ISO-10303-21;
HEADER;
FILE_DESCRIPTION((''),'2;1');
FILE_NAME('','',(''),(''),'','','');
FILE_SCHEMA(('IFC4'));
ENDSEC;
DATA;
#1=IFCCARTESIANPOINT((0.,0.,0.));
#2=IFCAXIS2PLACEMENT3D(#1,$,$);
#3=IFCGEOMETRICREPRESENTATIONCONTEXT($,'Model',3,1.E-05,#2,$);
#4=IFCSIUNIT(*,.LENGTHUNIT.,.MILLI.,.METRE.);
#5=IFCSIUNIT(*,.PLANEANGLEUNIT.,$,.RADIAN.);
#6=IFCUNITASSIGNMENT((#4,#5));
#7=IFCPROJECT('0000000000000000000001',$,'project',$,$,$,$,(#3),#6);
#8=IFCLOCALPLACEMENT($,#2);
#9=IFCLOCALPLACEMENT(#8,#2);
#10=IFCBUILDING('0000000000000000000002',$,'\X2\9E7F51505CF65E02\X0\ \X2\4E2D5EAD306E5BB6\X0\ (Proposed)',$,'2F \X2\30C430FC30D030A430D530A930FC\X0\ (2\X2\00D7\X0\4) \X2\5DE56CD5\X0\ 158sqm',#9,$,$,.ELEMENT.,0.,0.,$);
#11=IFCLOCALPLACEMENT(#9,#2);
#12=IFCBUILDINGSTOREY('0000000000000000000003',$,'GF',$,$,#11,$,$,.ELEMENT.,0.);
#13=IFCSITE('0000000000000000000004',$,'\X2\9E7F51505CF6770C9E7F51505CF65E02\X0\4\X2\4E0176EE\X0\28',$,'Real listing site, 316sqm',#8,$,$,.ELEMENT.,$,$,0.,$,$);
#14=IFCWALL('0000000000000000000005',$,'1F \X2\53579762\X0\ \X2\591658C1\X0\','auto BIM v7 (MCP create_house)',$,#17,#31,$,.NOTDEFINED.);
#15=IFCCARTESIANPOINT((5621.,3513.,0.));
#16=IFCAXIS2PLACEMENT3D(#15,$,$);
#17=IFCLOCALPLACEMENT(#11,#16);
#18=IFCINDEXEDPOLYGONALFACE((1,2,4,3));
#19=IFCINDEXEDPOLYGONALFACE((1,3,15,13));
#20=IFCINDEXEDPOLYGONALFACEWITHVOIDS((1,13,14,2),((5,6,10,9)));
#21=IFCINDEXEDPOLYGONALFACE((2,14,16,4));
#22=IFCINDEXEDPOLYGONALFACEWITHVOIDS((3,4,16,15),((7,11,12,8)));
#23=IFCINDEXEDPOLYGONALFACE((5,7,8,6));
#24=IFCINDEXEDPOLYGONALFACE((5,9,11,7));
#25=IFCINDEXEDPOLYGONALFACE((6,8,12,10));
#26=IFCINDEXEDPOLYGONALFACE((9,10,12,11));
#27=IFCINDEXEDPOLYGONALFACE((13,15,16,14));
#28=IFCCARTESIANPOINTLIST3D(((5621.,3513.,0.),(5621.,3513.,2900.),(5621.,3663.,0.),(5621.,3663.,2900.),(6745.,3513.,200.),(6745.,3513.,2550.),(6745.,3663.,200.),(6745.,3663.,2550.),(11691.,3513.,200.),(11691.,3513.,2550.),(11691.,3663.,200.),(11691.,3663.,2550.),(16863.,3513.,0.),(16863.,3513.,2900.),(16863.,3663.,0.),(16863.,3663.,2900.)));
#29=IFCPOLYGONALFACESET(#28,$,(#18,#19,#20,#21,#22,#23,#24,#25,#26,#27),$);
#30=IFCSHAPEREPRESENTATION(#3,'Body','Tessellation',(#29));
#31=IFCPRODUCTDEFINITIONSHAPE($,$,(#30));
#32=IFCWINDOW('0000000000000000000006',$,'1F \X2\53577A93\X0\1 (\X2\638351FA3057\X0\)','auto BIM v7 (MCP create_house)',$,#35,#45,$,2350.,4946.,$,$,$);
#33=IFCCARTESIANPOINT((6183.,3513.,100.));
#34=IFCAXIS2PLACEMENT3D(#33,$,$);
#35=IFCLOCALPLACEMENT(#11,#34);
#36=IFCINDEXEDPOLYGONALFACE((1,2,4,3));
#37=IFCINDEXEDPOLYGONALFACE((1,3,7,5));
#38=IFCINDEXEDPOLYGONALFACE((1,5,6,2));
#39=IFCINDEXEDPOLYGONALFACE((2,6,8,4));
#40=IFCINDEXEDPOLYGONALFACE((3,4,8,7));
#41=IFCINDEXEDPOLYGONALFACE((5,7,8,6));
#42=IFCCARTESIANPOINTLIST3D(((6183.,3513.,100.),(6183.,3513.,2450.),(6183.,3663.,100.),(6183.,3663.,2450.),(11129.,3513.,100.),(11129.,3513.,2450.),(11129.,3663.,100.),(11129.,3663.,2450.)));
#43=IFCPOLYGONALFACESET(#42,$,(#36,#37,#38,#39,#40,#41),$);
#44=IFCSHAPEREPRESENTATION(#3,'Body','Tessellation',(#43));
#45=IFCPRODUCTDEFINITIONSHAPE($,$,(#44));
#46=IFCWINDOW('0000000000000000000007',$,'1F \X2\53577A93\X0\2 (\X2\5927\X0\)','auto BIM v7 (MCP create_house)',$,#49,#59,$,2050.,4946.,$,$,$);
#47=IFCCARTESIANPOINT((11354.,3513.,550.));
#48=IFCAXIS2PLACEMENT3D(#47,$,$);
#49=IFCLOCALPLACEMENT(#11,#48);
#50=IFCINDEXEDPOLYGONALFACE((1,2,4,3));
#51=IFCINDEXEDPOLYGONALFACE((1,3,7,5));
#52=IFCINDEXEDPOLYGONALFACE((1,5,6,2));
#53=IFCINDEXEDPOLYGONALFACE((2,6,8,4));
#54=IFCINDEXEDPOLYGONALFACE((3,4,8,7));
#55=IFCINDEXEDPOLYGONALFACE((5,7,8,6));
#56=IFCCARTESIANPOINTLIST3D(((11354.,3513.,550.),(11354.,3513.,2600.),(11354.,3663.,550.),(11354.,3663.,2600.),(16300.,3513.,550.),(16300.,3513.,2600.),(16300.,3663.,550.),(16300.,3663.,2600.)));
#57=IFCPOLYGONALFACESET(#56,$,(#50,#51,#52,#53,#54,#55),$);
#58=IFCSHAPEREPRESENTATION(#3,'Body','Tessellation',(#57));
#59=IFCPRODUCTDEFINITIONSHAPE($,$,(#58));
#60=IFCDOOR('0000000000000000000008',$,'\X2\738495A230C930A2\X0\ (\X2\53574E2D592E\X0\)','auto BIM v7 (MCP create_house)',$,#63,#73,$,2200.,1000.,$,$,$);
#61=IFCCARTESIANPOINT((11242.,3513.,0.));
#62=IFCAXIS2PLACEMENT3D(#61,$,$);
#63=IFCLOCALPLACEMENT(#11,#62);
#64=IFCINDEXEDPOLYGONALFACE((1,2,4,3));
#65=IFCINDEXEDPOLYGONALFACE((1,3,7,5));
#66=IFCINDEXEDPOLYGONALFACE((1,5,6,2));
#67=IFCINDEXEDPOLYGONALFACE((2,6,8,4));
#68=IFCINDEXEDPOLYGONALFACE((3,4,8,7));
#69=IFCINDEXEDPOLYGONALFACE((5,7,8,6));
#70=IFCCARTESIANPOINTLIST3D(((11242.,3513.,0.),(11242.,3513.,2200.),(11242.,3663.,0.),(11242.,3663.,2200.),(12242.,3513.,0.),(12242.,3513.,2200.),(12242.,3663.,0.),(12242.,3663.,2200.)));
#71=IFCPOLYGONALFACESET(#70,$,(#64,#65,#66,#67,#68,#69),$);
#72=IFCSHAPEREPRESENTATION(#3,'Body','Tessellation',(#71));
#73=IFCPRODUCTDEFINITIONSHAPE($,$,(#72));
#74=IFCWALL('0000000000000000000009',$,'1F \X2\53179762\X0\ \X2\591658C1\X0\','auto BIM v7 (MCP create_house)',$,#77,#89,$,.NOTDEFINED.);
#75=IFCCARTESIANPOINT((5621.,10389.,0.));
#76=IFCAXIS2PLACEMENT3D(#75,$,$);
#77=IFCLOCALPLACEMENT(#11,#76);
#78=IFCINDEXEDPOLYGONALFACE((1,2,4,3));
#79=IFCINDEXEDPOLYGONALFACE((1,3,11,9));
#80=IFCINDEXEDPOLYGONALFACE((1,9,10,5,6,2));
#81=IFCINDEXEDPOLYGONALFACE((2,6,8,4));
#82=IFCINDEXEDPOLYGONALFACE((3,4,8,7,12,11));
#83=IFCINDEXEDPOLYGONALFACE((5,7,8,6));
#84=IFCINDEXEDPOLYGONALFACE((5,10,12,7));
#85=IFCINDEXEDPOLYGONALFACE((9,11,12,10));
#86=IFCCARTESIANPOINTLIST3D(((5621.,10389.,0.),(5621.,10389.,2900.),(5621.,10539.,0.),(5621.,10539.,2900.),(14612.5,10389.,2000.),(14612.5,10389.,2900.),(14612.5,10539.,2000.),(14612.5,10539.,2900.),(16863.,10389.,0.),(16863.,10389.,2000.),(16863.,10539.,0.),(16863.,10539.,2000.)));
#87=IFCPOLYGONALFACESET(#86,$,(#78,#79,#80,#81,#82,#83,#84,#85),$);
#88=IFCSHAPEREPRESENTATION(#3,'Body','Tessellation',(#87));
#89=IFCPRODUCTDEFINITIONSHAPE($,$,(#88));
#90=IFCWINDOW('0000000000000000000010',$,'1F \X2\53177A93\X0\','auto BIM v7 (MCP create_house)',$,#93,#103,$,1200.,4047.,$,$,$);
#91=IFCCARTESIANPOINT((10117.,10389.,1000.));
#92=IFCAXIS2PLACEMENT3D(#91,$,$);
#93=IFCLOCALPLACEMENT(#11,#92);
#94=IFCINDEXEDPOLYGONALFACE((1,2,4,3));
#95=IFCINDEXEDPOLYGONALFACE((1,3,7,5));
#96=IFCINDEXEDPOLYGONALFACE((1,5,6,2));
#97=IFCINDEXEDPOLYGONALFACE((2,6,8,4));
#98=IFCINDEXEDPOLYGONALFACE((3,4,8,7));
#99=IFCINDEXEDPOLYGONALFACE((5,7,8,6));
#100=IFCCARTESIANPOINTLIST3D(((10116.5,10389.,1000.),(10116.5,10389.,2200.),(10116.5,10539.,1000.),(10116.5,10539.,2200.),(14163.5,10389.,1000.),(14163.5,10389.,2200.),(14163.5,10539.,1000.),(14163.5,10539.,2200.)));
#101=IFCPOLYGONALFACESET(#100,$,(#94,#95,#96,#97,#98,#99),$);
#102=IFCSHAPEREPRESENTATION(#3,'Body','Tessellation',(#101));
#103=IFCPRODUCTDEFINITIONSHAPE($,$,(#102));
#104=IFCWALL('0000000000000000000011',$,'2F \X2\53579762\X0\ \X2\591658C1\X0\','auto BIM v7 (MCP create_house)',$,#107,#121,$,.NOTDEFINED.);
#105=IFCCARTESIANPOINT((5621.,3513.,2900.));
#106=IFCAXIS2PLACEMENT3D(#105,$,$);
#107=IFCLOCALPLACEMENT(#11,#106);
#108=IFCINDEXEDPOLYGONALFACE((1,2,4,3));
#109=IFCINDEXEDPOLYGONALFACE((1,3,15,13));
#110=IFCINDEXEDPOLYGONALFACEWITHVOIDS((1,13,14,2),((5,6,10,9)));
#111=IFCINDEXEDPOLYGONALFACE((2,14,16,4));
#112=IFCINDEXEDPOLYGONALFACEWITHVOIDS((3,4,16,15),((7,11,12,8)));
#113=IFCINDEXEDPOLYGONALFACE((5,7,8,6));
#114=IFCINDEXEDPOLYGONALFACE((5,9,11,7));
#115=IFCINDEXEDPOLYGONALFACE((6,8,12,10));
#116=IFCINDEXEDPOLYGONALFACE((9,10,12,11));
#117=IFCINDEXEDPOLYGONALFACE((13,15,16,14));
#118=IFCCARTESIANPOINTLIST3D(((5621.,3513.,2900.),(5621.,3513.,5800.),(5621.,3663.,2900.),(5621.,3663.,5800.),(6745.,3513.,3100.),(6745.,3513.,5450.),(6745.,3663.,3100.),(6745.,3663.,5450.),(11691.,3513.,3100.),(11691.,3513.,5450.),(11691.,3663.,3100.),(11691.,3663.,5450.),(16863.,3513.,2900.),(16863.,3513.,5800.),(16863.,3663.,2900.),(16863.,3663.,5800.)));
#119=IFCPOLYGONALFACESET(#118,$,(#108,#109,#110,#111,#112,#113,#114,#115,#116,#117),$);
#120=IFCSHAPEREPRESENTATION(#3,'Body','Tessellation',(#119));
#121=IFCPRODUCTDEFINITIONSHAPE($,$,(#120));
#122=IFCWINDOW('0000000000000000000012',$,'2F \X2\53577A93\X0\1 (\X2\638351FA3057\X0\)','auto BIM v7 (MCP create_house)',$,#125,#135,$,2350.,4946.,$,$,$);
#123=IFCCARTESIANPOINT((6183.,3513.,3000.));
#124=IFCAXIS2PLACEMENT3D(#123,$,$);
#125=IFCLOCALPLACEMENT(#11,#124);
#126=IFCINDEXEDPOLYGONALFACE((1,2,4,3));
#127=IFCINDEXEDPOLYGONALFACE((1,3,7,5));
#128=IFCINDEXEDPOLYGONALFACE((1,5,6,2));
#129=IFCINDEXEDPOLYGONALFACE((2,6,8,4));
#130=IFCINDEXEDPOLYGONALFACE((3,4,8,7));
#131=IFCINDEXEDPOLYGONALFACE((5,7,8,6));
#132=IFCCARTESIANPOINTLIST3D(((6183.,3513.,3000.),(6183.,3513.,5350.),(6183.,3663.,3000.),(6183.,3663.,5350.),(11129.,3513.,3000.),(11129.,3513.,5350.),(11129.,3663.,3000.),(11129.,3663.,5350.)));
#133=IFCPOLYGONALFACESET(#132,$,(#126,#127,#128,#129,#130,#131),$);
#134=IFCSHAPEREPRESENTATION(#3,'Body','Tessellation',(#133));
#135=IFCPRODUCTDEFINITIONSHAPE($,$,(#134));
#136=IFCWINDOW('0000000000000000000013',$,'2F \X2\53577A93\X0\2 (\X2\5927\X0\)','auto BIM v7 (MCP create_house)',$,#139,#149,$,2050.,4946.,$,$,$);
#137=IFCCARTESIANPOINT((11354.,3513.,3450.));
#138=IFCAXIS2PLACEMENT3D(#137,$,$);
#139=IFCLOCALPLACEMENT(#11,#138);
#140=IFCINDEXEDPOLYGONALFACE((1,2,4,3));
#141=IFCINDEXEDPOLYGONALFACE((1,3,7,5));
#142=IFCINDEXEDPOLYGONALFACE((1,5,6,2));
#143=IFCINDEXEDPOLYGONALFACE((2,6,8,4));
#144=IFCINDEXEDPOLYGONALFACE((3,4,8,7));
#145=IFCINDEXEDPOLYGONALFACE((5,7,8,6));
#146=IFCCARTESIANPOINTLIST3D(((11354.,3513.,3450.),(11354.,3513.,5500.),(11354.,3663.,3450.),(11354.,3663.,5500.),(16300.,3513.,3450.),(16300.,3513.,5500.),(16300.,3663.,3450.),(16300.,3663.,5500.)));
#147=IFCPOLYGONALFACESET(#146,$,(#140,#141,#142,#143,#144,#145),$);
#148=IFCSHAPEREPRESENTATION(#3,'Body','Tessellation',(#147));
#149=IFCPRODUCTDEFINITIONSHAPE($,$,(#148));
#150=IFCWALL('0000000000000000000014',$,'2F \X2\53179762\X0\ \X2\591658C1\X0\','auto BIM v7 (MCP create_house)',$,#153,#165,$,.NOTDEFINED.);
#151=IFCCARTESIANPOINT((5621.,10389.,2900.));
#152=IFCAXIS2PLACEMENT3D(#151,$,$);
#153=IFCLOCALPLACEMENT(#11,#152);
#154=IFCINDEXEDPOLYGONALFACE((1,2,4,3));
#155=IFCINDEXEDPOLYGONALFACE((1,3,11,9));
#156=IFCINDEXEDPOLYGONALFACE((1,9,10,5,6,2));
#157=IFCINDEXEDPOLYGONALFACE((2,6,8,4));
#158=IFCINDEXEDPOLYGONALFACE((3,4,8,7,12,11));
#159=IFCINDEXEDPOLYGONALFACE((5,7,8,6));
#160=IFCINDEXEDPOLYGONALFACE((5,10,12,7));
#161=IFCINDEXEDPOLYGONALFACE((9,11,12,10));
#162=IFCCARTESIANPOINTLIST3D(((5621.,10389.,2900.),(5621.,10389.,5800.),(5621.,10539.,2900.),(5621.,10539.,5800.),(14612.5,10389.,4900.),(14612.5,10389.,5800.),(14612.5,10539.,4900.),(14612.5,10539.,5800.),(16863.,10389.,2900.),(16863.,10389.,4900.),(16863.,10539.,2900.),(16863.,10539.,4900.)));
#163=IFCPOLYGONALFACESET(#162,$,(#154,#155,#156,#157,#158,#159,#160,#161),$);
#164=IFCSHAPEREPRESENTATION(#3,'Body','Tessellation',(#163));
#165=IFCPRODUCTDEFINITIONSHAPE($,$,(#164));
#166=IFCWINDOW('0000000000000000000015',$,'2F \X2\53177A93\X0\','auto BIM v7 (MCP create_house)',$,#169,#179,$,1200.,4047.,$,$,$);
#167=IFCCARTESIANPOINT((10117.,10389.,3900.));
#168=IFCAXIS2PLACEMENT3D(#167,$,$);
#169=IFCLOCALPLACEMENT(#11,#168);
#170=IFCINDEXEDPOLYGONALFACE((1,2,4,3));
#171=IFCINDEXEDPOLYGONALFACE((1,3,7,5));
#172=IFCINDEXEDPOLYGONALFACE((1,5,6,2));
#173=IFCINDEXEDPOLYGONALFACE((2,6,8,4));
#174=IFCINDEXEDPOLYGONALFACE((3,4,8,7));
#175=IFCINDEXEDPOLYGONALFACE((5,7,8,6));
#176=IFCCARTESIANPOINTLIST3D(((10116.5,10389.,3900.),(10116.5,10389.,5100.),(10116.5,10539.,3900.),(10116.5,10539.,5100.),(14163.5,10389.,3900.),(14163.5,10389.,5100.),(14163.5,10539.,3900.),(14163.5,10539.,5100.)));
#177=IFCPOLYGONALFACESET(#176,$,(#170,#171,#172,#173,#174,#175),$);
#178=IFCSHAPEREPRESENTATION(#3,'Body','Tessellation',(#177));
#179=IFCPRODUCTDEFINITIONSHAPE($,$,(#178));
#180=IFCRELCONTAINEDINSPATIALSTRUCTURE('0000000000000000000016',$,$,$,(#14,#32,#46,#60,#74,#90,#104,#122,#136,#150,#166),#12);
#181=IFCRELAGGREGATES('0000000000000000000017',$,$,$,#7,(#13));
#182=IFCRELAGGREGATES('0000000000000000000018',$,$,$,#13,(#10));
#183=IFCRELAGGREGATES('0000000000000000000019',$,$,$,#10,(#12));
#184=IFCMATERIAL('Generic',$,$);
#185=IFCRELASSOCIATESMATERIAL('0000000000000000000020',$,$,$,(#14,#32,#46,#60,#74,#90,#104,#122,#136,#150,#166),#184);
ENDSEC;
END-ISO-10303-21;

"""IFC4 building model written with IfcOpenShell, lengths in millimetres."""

from ifc_helpers import new_model, si_unit, frame, frame_2d, origin, place, context, project, spatial, rectangle, extrude, material, element, fill, save


model = new_model("IFC4")

# Units and contexts
model_context = context("Model", 3, precision=1e-05, world=origin())
ifc_project = project(units=[si_unit("LENGTHUNIT", "METRE", prefix="MILLI"), si_unit("PLANEANGLEUNIT", "RADIAN")], contexts=[model_context])

# Site, building, storey
site_placement = place(None, origin())
site = spatial("IfcSite", under=ifc_project, at=site_placement, Name="鹿児島県鹿児島市4丁目28", ObjectType="Real listing site, 316sqm", CompositionType="ELEMENT", RefElevation=0.0)
building_placement = place(site_placement, origin())
building = spatial("IfcBuilding", under=site, at=building_placement, Name="鹿児島市 中庭の家 (Proposed)", ObjectType="2F ツーバイフォー (2×4) 工法 158sqm", CompositionType="ELEMENT", ElevationOfRefHeight=0.0, ElevationOfTerrain=0.0)
storey_placement = place(building_placement, origin())
storey = spatial("IfcBuildingStorey", under=building, at=storey_placement, Name="GF", CompositionType="ELEMENT", Elevation=0.0)

# Shared definitions
ifc_material = material(Name="Generic")

# Wall, openings, windows, door
wall_1_placement = place(storey_placement, frame((5621.0, 3513.0, 0.0)))
wall_1 = element("IfcWall", 1, at=wall_1_placement, inside=storey, material=ifc_material, Name="1F 南面 外壁", Description="auto BIM v7 (MCP create_house)", PredefinedType="NOTDEFINED", context=model_context, shape_type="SweptSolid", body=[
    extrude(rectangle(XDim=11242.0, YDim=150.0, at=frame_2d((5621.0, 75.0))), frame((5621.0, 3513.0, 0.0)), (0.0, 0.0, 1.0), 2900.0),
])
opening_1_placement = place(storey_placement, frame((6183.0, 3513.0, 100.0)))
opening_1 = element("IfcOpeningElement", 2, at=opening_1_placement, cuts=wall_1, PredefinedType="NOTDEFINED", context=model_context, shape_type="SweptSolid", body=[
    extrude(rectangle(XDim=4946.0, YDim=150.0, at=frame_2d((2473.0, 75.0))), frame((6183.0, 3513.0, 100.0)), (0.0, 0.0, 1.0), 2350.0),
])
opening_2_placement = place(storey_placement, frame((11354.0, 3513.0, 550.0)))
opening_2 = element("IfcOpeningElement", 3, at=opening_2_placement, cuts=wall_1, PredefinedType="NOTDEFINED", context=model_context, shape_type="SweptSolid", body=[
    extrude(rectangle(XDim=4946.0, YDim=150.0, at=frame_2d((2473.0, 75.0))), frame((11354.0, 3513.0, 550.0)), (0.0, 0.0, 1.0), 2050.0),
])
opening_3_placement = place(storey_placement, frame((11242.0, 3513.0, 0.0)))
opening_3 = element("IfcOpeningElement", 4, at=opening_3_placement, cuts=wall_1, PredefinedType="NOTDEFINED", context=model_context, shape_type="SweptSolid", body=[
    extrude(rectangle(XDim=1000.0, YDim=150.0, at=frame_2d((500.0, 75.0))), frame((11242.0, 3513.0, 0.0)), (0.0, 0.0, 1.0), 2200.0),
])
window_1_placement = place(storey_placement, frame((6183.0, 3513.0, 100.0)))
window_1 = element("IfcWindow", 5, at=window_1_placement, inside=storey, material=ifc_material, Name="1F 南窓1 (掃出し)", Description="auto BIM v7 (MCP create_house)", OverallHeight=2350.0, OverallWidth=4946.0, context=model_context, shape_type="SweptSolid", body=[
    extrude(rectangle(XDim=4946.0, YDim=150.0, at=frame_2d((2473.0, 75.0))), frame((6183.0, 3513.0, 100.0)), (0.0, 0.0, 1.0), 2350.0),
])
fill(opening_1, window_1)
window_2_placement = place(storey_placement, frame((11354.0, 3513.0, 550.0)))
window_2 = element("IfcWindow", 6, at=window_2_placement, inside=storey, material=ifc_material, Name="1F 南窓2 (大)", Description="auto BIM v7 (MCP create_house)", OverallHeight=2050.0, OverallWidth=4946.0, context=model_context, shape_type="SweptSolid", body=[
    extrude(rectangle(XDim=4946.0, YDim=150.0, at=frame_2d((2473.0, 75.0))), frame((11354.0, 3513.0, 550.0)), (0.0, 0.0, 1.0), 2050.0),
])
fill(opening_2, window_2)
door_placement = place(storey_placement, frame((11242.0, 3513.0, 0.0)))
door = element("IfcDoor", 7, at=door_placement, inside=storey, material=ifc_material, Name="玄関ドア (南中央)", Description="auto BIM v7 (MCP create_house)", OverallHeight=2200.0, OverallWidth=1000.0, context=model_context, shape_type="SweptSolid", body=[
    extrude(rectangle(XDim=1000.0, YDim=150.0, at=frame_2d((500.0, 75.0))), frame((11242.0, 3513.0, 0.0)), (0.0, 0.0, 1.0), 2200.0),
])
fill(opening_3, door)

# Wall, opening, window
wall_2_placement = place(storey_placement, frame((5621.0, 10389.0, 0.0)))
wall_2 = element("IfcWall", 8, at=wall_2_placement, inside=storey, material=ifc_material, Name="1F 北面 外壁", Description="auto BIM v7 (MCP create_house)", PredefinedType="NOTDEFINED", context=model_context, shape_type="SweptSolid", body=[
    extrude(rectangle(XDim=11242.0, YDim=150.0, at=frame_2d((5621.0, 75.0))), frame((5621.0, 10389.0, 0.0)), (0.0, 0.0, 1.0), 2900.0),
])
opening_4_placement = place(storey_placement, frame((10117.0, 10389.0, 1000.0)))
opening_4 = element("IfcOpeningElement", 9, at=opening_4_placement, cuts=wall_2, PredefinedType="NOTDEFINED", context=model_context, shape_type="SweptSolid", body=[
    extrude(rectangle(XDim=4047.0, YDim=150.0, at=frame_2d((2023.0, 75.0))), frame((10117.0, 10389.0, 1000.0)), (0.0, 0.0, 1.0), 1200.0),
])
window_3_placement = place(storey_placement, frame((10117.0, 10389.0, 1000.0)))
window_3 = element("IfcWindow", 10, at=window_3_placement, inside=storey, material=ifc_material, Name="1F 北窓", Description="auto BIM v7 (MCP create_house)", OverallHeight=1200.0, OverallWidth=4047.0, context=model_context, shape_type="SweptSolid", body=[
    extrude(rectangle(XDim=4047.0, YDim=150.0, at=frame_2d((2023.0, 75.0))), frame((10117.0, 10389.0, 1000.0)), (0.0, 0.0, 1.0), 1200.0),
])
fill(opening_4, window_3)

# Wall, openings, windows
wall_3_placement = place(storey_placement, frame((5621.0, 3513.0, 2900.0)))
wall_3 = element("IfcWall", 11, at=wall_3_placement, inside=storey, material=ifc_material, Name="2F 南面 外壁", Description="auto BIM v7 (MCP create_house)", PredefinedType="NOTDEFINED", context=model_context, shape_type="SweptSolid", body=[
    extrude(rectangle(XDim=11242.0, YDim=150.0, at=frame_2d((5621.0, 75.0))), frame((5621.0, 3513.0, 2900.0)), (0.0, 0.0, 1.0), 2900.0),
])
opening_5_placement = place(storey_placement, frame((6183.0, 3513.0, 3000.0)))
opening_5 = element("IfcOpeningElement", 12, at=opening_5_placement, cuts=wall_3, PredefinedType="NOTDEFINED", context=model_context, shape_type="SweptSolid", body=[
    extrude(rectangle(XDim=4946.0, YDim=150.0, at=frame_2d((2473.0, 75.0))), frame((6183.0, 3513.0, 3000.0)), (0.0, 0.0, 1.0), 2350.0),
])
opening_6_placement = place(storey_placement, frame((11354.0, 3513.0, 3450.0)))
opening_6 = element("IfcOpeningElement", 13, at=opening_6_placement, cuts=wall_3, PredefinedType="NOTDEFINED", context=model_context, shape_type="SweptSolid", body=[
    extrude(rectangle(XDim=4946.0, YDim=150.0, at=frame_2d((2473.0, 75.0))), frame((11354.0, 3513.0, 3450.0)), (0.0, 0.0, 1.0), 2050.0),
])
window_4_placement = place(storey_placement, frame((6183.0, 3513.0, 3000.0)))
window_4 = element("IfcWindow", 14, at=window_4_placement, inside=storey, material=ifc_material, Name="2F 南窓1 (掃出し)", Description="auto BIM v7 (MCP create_house)", OverallHeight=2350.0, OverallWidth=4946.0, context=model_context, shape_type="SweptSolid", body=[
    extrude(rectangle(XDim=4946.0, YDim=150.0, at=frame_2d((2473.0, 75.0))), frame((6183.0, 3513.0, 3000.0)), (0.0, 0.0, 1.0), 2350.0),
])
fill(opening_5, window_4)
window_5_placement = place(storey_placement, frame((11354.0, 3513.0, 3450.0)))
window_5 = element("IfcWindow", 15, at=window_5_placement, inside=storey, material=ifc_material, Name="2F 南窓2 (大)", Description="auto BIM v7 (MCP create_house)", OverallHeight=2050.0, OverallWidth=4946.0, context=model_context, shape_type="SweptSolid", body=[
    extrude(rectangle(XDim=4946.0, YDim=150.0, at=frame_2d((2473.0, 75.0))), frame((11354.0, 3513.0, 3450.0)), (0.0, 0.0, 1.0), 2050.0),
])
fill(opening_6, window_5)

# Wall, opening, window
wall_4_placement = place(storey_placement, frame((5621.0, 10389.0, 2900.0)))
wall_4 = element("IfcWall", 16, at=wall_4_placement, inside=storey, material=ifc_material, Name="2F 北面 外壁", Description="auto BIM v7 (MCP create_house)", PredefinedType="NOTDEFINED", context=model_context, shape_type="SweptSolid", body=[
    extrude(rectangle(XDim=11242.0, YDim=150.0, at=frame_2d((5621.0, 75.0))), frame((5621.0, 10389.0, 2900.0)), (0.0, 0.0, 1.0), 2900.0),
])
opening_7_placement = place(storey_placement, frame((10117.0, 10389.0, 3900.0)))
opening_7 = element("IfcOpeningElement", 17, at=opening_7_placement, cuts=wall_4, PredefinedType="NOTDEFINED", context=model_context, shape_type="SweptSolid", body=[
    extrude(rectangle(XDim=4047.0, YDim=150.0, at=frame_2d((2023.0, 75.0))), frame((10117.0, 10389.0, 3900.0)), (0.0, 0.0, 1.0), 1200.0),
])
window_6_placement = place(storey_placement, frame((10117.0, 10389.0, 3900.0)))
window_6 = element("IfcWindow", 18, at=window_6_placement, inside=storey, material=ifc_material, Name="2F 北窓", Description="auto BIM v7 (MCP create_house)", OverallHeight=1200.0, OverallWidth=4047.0, context=model_context, shape_type="SweptSolid", body=[
    extrude(rectangle(XDim=4047.0, YDim=150.0, at=frame_2d((2023.0, 75.0))), frame((10117.0, 10389.0, 3900.0)), (0.0, 0.0, 1.0), 1200.0),
])
fill(opening_7, window_6)

save(model, "model.ifc")
